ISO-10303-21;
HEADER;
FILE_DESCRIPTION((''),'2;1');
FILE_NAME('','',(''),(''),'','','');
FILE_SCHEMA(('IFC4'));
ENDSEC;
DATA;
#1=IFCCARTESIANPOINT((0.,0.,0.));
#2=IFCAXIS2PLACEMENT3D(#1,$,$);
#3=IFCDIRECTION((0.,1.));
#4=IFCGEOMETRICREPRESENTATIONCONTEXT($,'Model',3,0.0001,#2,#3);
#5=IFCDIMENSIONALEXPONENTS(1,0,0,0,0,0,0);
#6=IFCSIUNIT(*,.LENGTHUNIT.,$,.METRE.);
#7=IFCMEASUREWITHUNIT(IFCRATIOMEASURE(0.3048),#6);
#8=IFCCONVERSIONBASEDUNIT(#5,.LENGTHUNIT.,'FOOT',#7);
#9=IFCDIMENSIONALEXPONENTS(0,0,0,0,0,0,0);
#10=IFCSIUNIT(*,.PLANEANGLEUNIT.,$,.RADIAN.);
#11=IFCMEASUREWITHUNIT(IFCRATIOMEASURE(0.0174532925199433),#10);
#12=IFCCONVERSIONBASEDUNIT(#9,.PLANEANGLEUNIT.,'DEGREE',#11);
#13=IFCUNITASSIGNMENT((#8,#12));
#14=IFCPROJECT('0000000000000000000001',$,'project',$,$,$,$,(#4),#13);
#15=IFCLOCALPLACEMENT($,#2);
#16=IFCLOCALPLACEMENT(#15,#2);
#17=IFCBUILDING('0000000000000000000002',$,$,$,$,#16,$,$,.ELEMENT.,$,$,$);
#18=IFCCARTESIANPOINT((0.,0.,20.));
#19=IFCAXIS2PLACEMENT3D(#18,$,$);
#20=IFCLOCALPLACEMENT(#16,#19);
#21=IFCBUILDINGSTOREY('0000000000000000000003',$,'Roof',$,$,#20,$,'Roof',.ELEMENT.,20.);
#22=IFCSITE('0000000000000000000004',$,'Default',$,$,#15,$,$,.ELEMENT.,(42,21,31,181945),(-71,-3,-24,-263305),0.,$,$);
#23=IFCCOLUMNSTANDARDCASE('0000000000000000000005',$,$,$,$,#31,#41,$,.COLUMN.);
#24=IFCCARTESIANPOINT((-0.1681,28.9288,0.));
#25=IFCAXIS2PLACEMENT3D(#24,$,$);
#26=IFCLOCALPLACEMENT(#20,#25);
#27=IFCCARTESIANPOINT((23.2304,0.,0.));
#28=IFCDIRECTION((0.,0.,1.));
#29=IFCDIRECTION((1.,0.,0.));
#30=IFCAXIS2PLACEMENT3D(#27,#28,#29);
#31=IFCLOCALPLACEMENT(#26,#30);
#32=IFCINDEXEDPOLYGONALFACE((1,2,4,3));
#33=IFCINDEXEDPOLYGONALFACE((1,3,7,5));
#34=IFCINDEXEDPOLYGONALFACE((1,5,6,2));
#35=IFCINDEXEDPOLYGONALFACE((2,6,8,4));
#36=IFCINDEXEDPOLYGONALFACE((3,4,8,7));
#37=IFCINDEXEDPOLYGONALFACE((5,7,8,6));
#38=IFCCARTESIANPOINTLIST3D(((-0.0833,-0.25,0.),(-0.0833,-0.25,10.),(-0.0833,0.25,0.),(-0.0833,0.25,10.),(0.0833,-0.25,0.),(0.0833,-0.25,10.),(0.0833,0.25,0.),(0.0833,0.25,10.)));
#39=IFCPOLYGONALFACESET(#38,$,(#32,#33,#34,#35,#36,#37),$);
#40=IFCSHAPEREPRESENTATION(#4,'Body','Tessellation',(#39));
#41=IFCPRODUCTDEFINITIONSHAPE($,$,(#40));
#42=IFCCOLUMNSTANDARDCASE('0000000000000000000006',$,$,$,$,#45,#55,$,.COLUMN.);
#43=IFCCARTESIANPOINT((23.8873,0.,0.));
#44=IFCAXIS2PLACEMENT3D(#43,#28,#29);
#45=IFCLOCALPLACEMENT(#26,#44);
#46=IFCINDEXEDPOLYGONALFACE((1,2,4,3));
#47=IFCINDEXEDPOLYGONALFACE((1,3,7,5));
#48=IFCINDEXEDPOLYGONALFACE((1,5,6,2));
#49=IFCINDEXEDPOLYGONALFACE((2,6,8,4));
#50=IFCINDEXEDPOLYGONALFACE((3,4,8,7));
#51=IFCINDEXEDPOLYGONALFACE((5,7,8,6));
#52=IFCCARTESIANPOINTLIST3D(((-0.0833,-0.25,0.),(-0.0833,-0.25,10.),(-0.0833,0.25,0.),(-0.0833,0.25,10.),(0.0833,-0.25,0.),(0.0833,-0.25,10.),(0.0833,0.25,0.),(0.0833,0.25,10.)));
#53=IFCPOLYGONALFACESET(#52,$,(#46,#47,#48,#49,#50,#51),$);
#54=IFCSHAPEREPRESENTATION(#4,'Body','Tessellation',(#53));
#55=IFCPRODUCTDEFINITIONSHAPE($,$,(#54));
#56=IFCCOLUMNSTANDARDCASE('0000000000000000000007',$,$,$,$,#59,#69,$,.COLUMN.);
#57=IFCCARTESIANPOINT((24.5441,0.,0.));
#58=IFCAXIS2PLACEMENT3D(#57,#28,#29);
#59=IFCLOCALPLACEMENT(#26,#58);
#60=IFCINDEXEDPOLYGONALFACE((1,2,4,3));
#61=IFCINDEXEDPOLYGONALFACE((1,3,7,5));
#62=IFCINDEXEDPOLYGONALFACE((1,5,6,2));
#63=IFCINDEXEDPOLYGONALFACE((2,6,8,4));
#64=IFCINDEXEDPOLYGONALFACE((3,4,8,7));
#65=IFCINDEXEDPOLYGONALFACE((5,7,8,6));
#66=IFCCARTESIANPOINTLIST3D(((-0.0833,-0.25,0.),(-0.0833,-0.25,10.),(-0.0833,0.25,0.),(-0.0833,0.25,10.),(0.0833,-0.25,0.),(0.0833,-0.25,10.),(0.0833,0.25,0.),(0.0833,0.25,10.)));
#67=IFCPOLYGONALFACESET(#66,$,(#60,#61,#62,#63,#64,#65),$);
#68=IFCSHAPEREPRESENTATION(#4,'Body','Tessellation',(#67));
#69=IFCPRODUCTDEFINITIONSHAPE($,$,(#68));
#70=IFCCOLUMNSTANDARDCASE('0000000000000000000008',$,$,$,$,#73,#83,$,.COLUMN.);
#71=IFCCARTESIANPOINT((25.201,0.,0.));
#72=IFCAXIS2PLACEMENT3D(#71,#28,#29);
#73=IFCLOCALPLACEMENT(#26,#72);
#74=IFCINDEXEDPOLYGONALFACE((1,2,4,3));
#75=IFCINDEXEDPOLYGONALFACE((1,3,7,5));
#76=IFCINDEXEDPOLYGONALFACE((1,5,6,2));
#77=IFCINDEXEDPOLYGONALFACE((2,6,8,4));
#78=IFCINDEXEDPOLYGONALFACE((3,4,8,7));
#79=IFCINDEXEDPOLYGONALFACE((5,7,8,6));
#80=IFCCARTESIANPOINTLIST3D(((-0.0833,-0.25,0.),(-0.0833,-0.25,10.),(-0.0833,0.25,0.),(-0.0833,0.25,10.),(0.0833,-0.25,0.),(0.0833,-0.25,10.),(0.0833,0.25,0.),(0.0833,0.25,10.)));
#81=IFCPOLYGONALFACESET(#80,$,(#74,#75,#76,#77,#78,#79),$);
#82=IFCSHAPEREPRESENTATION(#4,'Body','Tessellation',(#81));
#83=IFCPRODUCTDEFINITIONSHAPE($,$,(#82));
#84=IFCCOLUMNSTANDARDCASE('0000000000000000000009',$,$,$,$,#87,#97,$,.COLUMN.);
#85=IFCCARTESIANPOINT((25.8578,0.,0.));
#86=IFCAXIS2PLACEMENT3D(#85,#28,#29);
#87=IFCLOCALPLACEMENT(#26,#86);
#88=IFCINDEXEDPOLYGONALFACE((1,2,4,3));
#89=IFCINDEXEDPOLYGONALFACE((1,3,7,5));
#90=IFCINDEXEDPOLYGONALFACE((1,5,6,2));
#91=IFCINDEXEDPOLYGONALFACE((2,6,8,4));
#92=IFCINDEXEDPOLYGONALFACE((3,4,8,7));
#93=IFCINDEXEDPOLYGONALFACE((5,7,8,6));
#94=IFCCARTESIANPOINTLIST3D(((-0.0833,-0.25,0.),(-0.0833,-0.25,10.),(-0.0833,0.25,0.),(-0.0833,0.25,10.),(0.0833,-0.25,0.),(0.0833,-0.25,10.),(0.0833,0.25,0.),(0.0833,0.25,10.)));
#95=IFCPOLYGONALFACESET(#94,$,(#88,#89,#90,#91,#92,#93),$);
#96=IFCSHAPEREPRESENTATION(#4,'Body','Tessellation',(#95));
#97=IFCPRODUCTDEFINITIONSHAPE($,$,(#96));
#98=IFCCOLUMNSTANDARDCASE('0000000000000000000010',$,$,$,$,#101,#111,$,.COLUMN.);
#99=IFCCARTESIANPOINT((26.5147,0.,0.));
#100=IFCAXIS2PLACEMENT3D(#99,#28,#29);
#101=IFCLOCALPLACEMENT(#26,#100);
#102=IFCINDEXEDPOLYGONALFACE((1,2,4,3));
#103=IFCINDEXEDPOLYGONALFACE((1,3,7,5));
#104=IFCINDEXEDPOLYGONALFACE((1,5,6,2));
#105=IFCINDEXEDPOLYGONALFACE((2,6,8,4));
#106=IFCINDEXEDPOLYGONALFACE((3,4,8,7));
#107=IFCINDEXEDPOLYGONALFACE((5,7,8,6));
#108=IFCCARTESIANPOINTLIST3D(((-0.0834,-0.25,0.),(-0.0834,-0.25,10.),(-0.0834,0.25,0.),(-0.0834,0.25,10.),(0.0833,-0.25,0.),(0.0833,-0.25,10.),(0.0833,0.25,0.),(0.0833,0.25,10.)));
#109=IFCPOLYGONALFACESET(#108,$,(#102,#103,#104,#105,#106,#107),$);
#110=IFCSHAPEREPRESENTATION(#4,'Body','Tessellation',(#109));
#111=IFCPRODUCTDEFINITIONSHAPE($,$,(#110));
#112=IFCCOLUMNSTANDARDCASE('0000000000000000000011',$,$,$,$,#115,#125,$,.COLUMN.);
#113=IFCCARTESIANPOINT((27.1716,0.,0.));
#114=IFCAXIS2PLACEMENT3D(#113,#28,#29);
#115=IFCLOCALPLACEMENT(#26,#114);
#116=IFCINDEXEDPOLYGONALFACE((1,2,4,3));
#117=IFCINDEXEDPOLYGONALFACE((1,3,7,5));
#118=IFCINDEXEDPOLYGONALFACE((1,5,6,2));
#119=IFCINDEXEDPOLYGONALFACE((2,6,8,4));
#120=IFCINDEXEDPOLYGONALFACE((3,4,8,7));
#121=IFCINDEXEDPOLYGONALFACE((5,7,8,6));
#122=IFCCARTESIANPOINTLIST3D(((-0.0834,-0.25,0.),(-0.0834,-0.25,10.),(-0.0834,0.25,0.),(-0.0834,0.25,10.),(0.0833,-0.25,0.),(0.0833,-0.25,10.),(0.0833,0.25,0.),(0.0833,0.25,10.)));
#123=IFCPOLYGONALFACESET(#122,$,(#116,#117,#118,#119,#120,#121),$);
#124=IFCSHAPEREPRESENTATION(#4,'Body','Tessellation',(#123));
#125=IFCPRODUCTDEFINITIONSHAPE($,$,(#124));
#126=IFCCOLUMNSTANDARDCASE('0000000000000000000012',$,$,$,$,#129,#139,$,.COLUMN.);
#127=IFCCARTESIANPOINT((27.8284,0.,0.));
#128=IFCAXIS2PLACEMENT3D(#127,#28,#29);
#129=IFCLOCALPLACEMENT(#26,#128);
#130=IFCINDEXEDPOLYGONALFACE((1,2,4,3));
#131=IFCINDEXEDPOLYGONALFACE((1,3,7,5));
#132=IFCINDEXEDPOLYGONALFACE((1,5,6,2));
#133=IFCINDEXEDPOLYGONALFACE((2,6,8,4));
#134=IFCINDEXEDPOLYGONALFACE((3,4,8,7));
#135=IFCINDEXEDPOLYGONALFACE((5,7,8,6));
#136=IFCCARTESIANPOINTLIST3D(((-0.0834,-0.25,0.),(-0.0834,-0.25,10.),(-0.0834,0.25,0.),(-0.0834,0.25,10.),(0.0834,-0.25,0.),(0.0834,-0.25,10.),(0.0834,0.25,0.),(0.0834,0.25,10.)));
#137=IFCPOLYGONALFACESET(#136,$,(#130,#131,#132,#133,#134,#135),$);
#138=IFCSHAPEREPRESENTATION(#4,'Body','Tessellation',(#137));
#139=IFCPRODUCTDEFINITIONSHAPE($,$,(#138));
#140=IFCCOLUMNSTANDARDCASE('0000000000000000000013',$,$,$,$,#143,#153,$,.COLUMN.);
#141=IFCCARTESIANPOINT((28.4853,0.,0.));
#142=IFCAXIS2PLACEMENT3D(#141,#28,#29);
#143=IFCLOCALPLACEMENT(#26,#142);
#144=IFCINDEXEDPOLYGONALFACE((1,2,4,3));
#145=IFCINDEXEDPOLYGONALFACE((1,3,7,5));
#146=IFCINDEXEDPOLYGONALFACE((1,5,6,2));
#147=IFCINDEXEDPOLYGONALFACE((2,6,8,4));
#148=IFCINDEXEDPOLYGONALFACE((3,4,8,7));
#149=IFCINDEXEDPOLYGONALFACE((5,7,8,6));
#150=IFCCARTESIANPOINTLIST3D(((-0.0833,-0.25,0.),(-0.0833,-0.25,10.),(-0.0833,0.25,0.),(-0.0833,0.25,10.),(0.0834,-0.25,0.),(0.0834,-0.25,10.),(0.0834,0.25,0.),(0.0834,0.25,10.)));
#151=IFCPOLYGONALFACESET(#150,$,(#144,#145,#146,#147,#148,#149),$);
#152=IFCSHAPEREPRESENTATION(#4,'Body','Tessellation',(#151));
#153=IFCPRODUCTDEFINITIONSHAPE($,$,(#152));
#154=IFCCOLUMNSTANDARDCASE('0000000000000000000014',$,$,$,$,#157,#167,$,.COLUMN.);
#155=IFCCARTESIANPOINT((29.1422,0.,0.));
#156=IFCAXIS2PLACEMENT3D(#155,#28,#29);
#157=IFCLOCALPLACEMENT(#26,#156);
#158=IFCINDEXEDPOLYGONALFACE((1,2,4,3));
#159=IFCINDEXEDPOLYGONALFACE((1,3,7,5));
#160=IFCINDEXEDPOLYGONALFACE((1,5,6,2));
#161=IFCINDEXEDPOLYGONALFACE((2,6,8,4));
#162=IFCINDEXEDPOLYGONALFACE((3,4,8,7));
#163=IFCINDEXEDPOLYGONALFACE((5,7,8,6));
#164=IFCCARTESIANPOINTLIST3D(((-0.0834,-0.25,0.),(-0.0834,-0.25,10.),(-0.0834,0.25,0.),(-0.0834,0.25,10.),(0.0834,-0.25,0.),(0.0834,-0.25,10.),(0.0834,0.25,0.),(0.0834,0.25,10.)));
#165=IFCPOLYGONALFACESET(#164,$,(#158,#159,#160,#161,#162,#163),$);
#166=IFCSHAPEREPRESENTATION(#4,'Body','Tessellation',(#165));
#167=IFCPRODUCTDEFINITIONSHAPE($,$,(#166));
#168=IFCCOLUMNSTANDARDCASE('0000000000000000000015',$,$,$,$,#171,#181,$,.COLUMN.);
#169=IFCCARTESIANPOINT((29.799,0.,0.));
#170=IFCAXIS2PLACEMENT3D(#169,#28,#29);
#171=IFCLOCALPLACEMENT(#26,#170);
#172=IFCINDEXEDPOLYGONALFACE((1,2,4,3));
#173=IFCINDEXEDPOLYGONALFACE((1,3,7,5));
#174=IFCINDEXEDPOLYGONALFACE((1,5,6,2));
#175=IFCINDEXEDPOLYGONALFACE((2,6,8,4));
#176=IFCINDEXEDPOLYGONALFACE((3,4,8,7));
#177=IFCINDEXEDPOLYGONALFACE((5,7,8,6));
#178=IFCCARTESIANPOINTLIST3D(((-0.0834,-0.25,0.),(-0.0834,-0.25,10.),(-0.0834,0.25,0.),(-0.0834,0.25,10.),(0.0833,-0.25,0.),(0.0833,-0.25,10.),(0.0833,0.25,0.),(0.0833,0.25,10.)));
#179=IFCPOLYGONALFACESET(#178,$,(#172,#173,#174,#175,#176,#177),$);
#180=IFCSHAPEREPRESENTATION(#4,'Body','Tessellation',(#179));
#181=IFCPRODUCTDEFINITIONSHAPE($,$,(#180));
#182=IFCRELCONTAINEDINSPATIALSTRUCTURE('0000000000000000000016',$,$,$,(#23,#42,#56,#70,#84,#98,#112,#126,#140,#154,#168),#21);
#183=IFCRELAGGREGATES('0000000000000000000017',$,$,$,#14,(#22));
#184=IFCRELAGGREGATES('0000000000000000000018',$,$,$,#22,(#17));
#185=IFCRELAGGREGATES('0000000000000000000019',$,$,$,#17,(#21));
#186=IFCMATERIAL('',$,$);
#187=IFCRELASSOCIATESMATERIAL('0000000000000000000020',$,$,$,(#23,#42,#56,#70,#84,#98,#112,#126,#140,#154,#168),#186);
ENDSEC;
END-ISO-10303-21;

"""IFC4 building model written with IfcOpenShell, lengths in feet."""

from ifc_helpers import new_model, entity, si_unit, converted_unit, direction, frame, origin, place, context, project, spatial, rectangle, extrude, material, element, save


model = new_model("IFC4")

# Units and contexts
model_context = context("Model", 3, precision=0.0001, world=origin(), true_north=direction((0.0, 1.0)))
ifc_project = project(units=[converted_unit("LENGTHUNIT", "FOOT", entity("IfcRatioMeasure", 0.3048), si_unit("LENGTHUNIT", "METRE"), dimensions=[1, 0, 0, 0, 0, 0, 0]), converted_unit("PLANEANGLEUNIT", "DEGREE", entity("IfcRatioMeasure", 0.0174532925199433), si_unit("PLANEANGLEUNIT", "RADIAN"), dimensions=[0, 0, 0, 0, 0, 0, 0])], contexts=[model_context])

# Site, building, storey
site_placement = place(None, origin())
site = spatial("IfcSite", under=ifc_project, at=site_placement, Name="Default", CompositionType="ELEMENT", RefLatitude=(42, 21, 31, 181945), RefLongitude=(-71, -3, -24, -263305), RefElevation=0.0)
building_placement = place(site_placement, origin())
building = spatial("IfcBuilding", under=site, at=building_placement, CompositionType="ELEMENT")
storey_placement = place(building_placement, frame((0.0, 0.0, 20.0)))
storey = spatial("IfcBuildingStorey", under=building, at=storey_placement, Name="Roof", LongName="Roof", CompositionType="ELEMENT", Elevation=20.0)

# Columns
ifc_material = material(Name="")
placement = place(storey_placement, frame((-0.1681, 28.9288, 0.0)))
for number, where, z_axis, x_axis in (
    (1, (23.2304, 0.0, 0.0), (0.0, 0.0, 1.0), (1.0, 0.0, 0.0)),
    (2, (23.8873, 0.0, 0.0), (0.0, 0.0, 1.0), (1.0, 0.0, 0.0)),
    (3, (24.5441, 0.0, 0.0), (0.0, 0.0, 1.0), (1.0, 0.0, 0.0)),
    (4, (25.201, 0.0, 0.0), (0.0, 0.0, 1.0), (1.0, 0.0, 0.0)),
    (5, (25.8578, 0.0, 0.0), (0.0, 0.0, 1.0), (1.0, 0.0, 0.0)),
    (6, (26.5147, 0.0, 0.0), (0.0, 0.0, 1.0), (1.0, 0.0, 0.0)),
    (7, (27.1716, 0.0, 0.0), (0.0, 0.0, 1.0), (1.0, 0.0, 0.0)),
    (8, (27.8284, 0.0, 0.0), (0.0, 0.0, 1.0), (1.0, 0.0, 0.0)),
    (9, (28.4853, 0.0, 0.0), (0.0, 0.0, 1.0), (1.0, 0.0, 0.0)),
    (10, (29.1422, 0.0, 0.0), (0.0, 0.0, 1.0), (1.0, 0.0, 0.0)),
    (11, (29.799, 0.0, 0.0), (0.0, 0.0, 1.0), (1.0, 0.0, 0.0)),
):
    element("IfcColumnStandardCase", number, at=place(placement, frame(where, z_axis=z_axis, x_axis=x_axis)), inside=storey, material=ifc_material, PredefinedType="COLUMN", context=model_context, shape_type="SweptSolid", body=[
        extrude(rectangle(XDim=0.1667, YDim=0.5), origin(), (0.0, 0.0, 1.0), 10.0),
    ])

save(model, "model.ifc")
